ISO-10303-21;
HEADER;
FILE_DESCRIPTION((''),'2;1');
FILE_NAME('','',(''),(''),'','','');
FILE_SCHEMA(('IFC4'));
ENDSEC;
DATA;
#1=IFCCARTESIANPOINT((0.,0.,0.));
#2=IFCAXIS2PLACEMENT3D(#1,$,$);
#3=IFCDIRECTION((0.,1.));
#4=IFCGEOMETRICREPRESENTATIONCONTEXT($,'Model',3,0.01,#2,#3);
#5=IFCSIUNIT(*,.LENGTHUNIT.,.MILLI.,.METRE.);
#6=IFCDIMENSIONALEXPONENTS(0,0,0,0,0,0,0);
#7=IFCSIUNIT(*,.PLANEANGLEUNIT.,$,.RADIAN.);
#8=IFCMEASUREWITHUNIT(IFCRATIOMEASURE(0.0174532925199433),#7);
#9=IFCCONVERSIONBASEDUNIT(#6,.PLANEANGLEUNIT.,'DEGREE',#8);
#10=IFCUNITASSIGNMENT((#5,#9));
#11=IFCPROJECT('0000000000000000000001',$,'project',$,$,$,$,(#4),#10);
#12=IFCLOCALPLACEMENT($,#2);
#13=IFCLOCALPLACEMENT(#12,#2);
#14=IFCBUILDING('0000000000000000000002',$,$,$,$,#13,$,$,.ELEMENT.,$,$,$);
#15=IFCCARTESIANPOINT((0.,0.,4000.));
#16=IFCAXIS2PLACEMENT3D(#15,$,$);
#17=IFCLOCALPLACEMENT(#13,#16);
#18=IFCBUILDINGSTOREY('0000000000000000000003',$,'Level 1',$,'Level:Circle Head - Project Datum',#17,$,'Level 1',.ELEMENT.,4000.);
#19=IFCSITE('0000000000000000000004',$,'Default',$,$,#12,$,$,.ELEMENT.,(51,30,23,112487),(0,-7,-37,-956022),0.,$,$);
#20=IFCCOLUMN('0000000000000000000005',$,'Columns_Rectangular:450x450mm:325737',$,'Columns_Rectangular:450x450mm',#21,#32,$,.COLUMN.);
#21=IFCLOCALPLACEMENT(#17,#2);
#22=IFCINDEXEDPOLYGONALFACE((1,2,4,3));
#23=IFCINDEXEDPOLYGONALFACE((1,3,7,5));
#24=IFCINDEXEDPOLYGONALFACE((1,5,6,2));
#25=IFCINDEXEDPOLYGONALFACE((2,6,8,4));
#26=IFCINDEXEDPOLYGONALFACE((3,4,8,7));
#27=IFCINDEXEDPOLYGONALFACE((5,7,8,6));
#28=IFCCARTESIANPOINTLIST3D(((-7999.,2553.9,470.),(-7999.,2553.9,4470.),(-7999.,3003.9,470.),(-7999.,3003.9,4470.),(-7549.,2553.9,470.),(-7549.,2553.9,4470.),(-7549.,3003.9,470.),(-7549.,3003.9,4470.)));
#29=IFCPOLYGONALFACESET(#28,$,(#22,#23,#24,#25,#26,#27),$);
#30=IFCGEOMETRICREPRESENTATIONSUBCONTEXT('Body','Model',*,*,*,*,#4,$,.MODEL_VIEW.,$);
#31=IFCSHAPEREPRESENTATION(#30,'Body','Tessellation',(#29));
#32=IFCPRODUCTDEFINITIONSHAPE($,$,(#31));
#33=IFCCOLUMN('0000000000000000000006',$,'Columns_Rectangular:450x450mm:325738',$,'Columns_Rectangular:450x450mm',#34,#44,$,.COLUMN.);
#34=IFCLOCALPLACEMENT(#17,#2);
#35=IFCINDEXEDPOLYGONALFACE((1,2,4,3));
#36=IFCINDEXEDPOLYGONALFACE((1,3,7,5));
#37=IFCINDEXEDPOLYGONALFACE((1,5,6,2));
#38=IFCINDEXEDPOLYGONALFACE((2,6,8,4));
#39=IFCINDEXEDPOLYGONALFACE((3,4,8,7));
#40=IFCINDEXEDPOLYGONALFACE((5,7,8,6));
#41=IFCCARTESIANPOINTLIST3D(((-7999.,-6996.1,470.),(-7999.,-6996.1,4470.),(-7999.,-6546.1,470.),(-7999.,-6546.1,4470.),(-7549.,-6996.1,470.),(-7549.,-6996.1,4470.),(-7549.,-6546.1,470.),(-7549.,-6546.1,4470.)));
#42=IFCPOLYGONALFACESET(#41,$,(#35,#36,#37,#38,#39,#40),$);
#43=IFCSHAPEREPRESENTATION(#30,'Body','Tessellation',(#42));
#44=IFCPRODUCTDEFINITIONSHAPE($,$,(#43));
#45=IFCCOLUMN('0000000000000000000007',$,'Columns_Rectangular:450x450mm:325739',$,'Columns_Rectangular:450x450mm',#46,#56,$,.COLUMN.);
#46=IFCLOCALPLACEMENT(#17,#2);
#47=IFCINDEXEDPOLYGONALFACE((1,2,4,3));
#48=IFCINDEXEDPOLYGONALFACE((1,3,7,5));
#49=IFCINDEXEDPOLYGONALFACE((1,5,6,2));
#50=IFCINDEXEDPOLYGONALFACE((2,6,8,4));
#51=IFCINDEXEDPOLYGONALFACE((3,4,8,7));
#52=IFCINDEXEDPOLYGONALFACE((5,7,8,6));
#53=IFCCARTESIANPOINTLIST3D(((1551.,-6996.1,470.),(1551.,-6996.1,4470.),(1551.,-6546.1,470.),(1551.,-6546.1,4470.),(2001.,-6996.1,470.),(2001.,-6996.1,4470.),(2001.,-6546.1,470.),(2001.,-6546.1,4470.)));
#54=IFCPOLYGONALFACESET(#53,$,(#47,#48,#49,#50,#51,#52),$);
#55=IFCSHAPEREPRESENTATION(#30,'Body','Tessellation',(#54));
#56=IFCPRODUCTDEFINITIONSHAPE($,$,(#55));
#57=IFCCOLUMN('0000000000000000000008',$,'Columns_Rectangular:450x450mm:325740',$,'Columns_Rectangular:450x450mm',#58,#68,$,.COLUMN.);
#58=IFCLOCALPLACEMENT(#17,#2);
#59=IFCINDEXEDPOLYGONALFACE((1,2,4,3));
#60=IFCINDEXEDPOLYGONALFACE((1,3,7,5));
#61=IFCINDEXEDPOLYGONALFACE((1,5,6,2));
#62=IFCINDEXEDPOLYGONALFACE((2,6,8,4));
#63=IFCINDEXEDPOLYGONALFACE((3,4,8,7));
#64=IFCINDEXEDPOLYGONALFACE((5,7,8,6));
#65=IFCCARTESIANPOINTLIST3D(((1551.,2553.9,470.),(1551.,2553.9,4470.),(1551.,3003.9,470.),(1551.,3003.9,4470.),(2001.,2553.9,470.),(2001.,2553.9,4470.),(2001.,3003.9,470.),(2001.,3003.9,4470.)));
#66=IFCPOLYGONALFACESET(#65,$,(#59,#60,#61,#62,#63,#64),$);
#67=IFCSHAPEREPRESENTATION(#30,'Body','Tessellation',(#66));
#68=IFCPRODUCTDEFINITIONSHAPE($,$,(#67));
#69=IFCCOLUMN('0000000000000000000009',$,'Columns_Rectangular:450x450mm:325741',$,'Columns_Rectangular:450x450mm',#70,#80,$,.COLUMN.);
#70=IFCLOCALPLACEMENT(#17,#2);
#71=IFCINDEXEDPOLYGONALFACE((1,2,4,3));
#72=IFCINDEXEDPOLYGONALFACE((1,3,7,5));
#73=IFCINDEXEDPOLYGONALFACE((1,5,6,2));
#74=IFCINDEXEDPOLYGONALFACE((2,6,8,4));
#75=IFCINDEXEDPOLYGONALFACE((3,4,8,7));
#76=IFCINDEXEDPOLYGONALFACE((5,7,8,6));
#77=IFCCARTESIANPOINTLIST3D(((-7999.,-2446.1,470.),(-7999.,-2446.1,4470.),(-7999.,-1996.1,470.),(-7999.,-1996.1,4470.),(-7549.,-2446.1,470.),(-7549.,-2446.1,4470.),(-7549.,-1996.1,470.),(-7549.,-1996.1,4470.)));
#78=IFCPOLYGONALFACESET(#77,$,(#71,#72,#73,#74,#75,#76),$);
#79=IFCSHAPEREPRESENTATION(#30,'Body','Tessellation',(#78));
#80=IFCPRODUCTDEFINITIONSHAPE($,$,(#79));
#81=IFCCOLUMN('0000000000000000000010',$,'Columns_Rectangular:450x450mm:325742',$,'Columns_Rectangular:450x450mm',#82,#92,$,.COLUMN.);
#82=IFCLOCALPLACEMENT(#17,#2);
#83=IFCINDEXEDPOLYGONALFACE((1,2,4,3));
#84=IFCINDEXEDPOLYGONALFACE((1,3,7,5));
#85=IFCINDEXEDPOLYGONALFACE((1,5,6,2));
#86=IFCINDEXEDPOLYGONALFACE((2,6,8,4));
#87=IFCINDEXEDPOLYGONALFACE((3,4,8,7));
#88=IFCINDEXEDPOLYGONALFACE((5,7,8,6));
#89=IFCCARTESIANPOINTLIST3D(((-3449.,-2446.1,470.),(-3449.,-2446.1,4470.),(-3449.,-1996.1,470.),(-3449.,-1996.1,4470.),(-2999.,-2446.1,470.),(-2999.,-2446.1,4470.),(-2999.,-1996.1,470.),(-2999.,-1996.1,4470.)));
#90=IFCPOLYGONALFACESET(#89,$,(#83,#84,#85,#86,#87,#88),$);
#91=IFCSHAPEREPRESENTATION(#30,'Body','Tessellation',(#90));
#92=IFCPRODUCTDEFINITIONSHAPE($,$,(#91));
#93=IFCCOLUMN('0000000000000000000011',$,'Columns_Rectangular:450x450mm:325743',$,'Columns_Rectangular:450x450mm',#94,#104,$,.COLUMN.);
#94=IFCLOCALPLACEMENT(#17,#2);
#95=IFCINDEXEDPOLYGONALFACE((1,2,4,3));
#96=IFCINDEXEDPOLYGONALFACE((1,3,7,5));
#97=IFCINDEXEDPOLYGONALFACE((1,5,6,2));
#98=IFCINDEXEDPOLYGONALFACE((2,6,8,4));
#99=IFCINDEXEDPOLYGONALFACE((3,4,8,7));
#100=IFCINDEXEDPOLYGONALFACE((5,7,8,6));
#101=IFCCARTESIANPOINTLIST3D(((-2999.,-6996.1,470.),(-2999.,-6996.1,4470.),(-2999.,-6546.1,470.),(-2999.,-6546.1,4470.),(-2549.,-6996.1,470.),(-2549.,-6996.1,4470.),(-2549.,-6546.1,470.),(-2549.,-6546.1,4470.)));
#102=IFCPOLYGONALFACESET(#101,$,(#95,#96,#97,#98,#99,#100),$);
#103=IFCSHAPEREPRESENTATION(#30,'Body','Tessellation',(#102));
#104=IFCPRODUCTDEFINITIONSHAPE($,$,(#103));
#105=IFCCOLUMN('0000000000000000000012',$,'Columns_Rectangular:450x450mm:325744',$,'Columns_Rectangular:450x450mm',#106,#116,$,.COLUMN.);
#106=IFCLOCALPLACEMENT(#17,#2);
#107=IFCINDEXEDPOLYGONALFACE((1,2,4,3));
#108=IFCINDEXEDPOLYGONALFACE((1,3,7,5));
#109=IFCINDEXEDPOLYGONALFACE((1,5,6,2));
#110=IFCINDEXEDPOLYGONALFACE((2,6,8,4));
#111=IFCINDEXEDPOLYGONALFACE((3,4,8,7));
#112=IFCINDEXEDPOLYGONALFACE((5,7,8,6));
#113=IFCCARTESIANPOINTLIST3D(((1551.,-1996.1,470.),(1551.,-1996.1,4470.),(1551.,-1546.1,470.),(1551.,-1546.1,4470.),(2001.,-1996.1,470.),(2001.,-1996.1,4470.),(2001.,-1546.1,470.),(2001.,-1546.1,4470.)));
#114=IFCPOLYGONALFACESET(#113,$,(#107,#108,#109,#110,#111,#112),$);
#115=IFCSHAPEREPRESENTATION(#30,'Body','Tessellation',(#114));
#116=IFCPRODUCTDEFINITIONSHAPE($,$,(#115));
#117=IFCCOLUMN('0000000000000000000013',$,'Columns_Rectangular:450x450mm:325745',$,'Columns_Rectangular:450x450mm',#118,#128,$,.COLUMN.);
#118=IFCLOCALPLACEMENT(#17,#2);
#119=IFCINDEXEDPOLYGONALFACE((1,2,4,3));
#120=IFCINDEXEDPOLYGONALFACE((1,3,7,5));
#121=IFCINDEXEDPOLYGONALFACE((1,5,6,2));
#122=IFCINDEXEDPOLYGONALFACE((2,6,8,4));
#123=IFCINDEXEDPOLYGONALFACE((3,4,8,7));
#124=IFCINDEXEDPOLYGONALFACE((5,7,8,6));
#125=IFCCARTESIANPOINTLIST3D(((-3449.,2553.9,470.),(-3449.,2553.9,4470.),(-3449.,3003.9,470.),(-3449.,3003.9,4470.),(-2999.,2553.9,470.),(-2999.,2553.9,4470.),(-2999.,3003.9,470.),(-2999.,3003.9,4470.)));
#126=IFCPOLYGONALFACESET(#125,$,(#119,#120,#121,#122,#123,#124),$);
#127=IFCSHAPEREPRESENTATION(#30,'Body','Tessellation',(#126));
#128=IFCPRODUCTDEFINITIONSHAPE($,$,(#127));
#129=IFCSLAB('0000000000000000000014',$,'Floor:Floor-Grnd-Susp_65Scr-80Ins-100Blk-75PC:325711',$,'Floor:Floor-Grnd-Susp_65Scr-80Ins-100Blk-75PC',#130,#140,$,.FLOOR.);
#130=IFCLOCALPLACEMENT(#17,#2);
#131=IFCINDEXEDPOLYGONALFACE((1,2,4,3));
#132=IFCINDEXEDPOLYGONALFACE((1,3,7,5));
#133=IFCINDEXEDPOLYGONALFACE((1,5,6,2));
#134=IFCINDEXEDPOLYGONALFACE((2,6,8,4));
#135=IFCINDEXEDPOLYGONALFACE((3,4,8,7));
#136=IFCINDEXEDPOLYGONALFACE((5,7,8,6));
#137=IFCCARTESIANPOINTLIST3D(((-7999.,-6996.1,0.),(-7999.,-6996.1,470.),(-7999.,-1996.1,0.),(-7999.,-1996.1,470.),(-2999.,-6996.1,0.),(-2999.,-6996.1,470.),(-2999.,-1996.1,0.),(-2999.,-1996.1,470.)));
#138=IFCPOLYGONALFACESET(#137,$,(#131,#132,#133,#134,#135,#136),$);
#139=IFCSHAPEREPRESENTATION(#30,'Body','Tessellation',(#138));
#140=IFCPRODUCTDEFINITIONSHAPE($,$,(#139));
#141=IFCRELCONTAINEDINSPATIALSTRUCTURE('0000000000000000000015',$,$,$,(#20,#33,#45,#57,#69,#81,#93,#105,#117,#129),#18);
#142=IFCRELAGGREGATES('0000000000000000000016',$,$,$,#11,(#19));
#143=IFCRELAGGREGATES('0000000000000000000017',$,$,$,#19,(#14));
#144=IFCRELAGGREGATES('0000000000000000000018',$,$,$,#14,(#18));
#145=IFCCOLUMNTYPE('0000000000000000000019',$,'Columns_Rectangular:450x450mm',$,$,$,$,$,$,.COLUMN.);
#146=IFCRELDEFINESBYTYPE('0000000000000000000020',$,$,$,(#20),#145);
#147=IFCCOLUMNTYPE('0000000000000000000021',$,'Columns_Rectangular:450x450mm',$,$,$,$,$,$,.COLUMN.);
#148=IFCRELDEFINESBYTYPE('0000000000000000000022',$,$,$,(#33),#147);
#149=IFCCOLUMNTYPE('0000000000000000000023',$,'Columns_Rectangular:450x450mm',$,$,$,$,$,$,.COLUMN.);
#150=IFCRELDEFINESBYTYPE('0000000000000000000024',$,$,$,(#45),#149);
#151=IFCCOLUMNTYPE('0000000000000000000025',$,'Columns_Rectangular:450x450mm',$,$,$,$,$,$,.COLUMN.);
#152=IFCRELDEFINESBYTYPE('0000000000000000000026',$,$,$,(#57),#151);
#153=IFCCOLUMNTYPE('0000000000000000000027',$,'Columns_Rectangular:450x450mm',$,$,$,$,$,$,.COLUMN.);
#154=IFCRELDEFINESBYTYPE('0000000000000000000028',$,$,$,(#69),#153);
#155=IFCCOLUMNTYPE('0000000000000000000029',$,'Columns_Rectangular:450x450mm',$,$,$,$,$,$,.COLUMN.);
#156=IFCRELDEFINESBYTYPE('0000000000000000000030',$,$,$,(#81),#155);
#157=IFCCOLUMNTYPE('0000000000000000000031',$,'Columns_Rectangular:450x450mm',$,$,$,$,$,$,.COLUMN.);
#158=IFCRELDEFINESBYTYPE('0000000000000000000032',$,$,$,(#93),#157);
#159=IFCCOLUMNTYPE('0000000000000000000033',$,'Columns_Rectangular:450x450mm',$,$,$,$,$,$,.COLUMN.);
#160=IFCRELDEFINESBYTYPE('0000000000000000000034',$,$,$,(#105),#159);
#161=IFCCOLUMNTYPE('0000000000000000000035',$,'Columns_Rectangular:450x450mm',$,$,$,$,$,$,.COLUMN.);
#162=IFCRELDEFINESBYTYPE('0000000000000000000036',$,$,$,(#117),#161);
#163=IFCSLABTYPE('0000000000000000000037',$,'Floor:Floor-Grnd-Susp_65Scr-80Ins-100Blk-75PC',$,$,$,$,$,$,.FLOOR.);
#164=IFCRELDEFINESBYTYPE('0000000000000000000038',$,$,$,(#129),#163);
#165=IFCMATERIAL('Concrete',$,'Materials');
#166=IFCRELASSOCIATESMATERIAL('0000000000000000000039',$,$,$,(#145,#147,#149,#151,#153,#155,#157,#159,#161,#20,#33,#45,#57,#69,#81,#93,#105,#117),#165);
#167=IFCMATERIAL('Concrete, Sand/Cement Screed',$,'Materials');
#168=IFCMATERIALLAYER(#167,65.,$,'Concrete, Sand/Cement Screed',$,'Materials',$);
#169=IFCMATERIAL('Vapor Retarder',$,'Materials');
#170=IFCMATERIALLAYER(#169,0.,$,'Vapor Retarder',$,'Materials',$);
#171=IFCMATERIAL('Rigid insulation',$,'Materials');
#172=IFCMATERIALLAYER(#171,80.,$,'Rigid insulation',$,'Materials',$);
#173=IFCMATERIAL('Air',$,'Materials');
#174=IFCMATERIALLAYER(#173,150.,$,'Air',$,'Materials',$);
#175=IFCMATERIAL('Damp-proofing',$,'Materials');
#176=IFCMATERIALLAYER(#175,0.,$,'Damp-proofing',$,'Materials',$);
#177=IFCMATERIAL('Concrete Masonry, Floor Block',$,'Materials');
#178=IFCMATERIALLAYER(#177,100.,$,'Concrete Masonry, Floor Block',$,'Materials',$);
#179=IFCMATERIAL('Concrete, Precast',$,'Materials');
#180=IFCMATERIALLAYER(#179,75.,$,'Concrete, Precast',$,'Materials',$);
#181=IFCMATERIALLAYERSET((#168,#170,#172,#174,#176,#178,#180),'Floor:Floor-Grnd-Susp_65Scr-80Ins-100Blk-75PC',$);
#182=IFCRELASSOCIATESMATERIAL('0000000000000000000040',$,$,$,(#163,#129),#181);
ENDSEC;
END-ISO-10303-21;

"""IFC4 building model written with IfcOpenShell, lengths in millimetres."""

from ifc_helpers import new_model, entity, si_unit, converted_unit, direction, frame, frame_2d, origin, origin_2d_with_axis, place, context, subcontext, project, spatial, polyline, segment, composite_curve, rectangle, outline, extrude, source, transform, mapped, material, layer, layer_set, layer_usage, material_profile, profile_set, profile_usage, type_object, type_shapes, element, save


model = new_model("IFC4")

# Units and contexts
model_context = context("Model", 3, precision=0.01, world=origin(), true_north=direction((0.0, 1.0)))
body_context = subcontext(model_context, "Body", "Model", "MODEL_VIEW")
ifc_project = project(units=[si_unit("LENGTHUNIT", "METRE", prefix="MILLI"), converted_unit("PLANEANGLEUNIT", "DEGREE", entity("IfcRatioMeasure", 0.0174532925199433), si_unit("PLANEANGLEUNIT", "RADIAN"), dimensions=[0, 0, 0, 0, 0, 0, 0])], contexts=[model_context])

# Site, building, storey
site_placement = place(None, origin())
site = spatial("IfcSite", under=ifc_project, at=site_placement, Name="Default", CompositionType="ELEMENT", RefLatitude=(51, 30, 23, 112487), RefLongitude=(0, -7, -37, -956022), RefElevation=0.0)
building_placement = place(site_placement, origin())
building = spatial("IfcBuilding", under=site, at=building_placement, CompositionType="ELEMENT")
storey_placement = place(building_placement, frame((0.0, 0.0, 4000.0)))
storey = spatial("IfcBuildingStorey", under=building, at=storey_placement, Name="Level 1", ObjectType="Level:Circle Head - Project Datum", LongName="Level 1", CompositionType="ELEMENT", Elevation=4000.0)

# Columns
ifc_material_1 = material(Name="Concrete", Category="Materials")
ifc_material_profile = material_profile(ifc_material_1, outline(composite_curve([segment(polyline([(225.0, 225.0, 0.0), (225.0, -225.0, 0.0)]), True, "CONTINUOUS"), segment(polyline([(225.0, -225.0, 0.0), (-225.0, -225.0, 0.0)]), True, "CONTINUOUS"), segment(polyline([(-225.0, -225.0, 0.0), (-225.0, 225.0, 0.0)]), True, "CONTINUOUS"), segment(polyline([(-225.0, 225.0, 0.0), (225.0, 225.0, 0.0)]), True, "CONTINUOUS")], self_intersect=False), kind="CURVE"), Name="450x450mm")
ifc_profile_set = profile_set([ifc_material_profile], Name="450x450mm")
ifc_profile_usage_1 = profile_usage(ifc_profile_set)
column_type_1 = type_object("IfcColumnType", Name="Columns_Rectangular:450x450mm", PredefinedType="COLUMN", material=ifc_profile_set)
shared_shape_1 = source(origin(), body_context, "Body", "SweptSolid", [
    extrude(rectangle(XDim=450.0, YDim=450.0, at=frame_2d((0.0, 0.0), x_axis=(1.0, 0.0))), frame((-7774.0, 2778.9, 4470.0), z_axis=(0.0, 0.0, 1.0), x_axis=(0.0, -1.0, 0.0)), (0.0, 0.0, 1.0), 4000.0),
])
type_shapes(column_type_1, [shared_shape_1])
column_1_placement = place(storey_placement, frame((0.0, 0.0, -4000.0)))
element("IfcColumn", 1, at=column_1_placement, inside=storey, type_object=column_type_1, material=ifc_profile_usage_1, Name="Columns_Rectangular:450x450mm:325737", ObjectType="Columns_Rectangular:450x450mm", PredefinedType="COLUMN", context=body_context, shape_type="MappedRepresentation", body=[
    mapped(shared_shape_1, transform((0.0, 0.0, 0.0), scale=1.0)),
])
ifc_profile_usage_2 = profile_usage(ifc_profile_set)
column_type_2 = type_object("IfcColumnType", Name="Columns_Rectangular:450x450mm", PredefinedType="COLUMN", material=ifc_profile_set)
shared_shape_2 = source(origin(), body_context, "Body", "SweptSolid", [
    extrude(rectangle(XDim=450.0, YDim=450.0, at=frame_2d((0.0, 0.0), x_axis=(1.0, 0.0))), frame((-7774.0, -6771.1, 4470.0), z_axis=(0.0, 0.0, 1.0), x_axis=(0.0, -1.0, 0.0)), (0.0, 0.0, 1.0), 4000.0),
])
type_shapes(column_type_2, [shared_shape_2])
column_2_placement = place(storey_placement, frame((0.0, 0.0, -4000.0)))
element("IfcColumn", 2, at=column_2_placement, inside=storey, type_object=column_type_2, material=ifc_profile_usage_2, Name="Columns_Rectangular:450x450mm:325738", ObjectType="Columns_Rectangular:450x450mm", PredefinedType="COLUMN", context=body_context, shape_type="MappedRepresentation", body=[
    mapped(shared_shape_2, transform((0.0, 0.0, 0.0), scale=1.0)),
])
ifc_profile_usage_3 = profile_usage(ifc_profile_set)
column_type_3 = type_object("IfcColumnType", Name="Columns_Rectangular:450x450mm", PredefinedType="COLUMN", material=ifc_profile_set)
shared_shape_3 = source(origin(), body_context, "Body", "SweptSolid", [
    extrude(rectangle(XDim=450.0, YDim=450.0, at=frame_2d((0.0, 0.0), x_axis=(1.0, 0.0))), frame((1776.0, -6771.1, 4470.0), z_axis=(0.0, 0.0, 1.0), x_axis=(0.0, -1.0, 0.0)), (0.0, 0.0, 1.0), 4000.0),
])
type_shapes(column_type_3, [shared_shape_3])
column_3_placement = place(storey_placement, frame((0.0, 0.0, -4000.0)))
element("IfcColumn", 3, at=column_3_placement, inside=storey, type_object=column_type_3, material=ifc_profile_usage_3, Name="Columns_Rectangular:450x450mm:325739", ObjectType="Columns_Rectangular:450x450mm", PredefinedType="COLUMN", context=body_context, shape_type="MappedRepresentation", body=[
    mapped(shared_shape_3, transform((0.0, 0.0, 0.0), scale=1.0)),
])
ifc_profile_usage_4 = profile_usage(ifc_profile_set)
column_type_4 = type_object("IfcColumnType", Name="Columns_Rectangular:450x450mm", PredefinedType="COLUMN", material=ifc_profile_set)
shared_shape_4 = source(origin(), body_context, "Body", "SweptSolid", [
    extrude(rectangle(XDim=450.0, YDim=450.0, at=frame_2d((0.0, 0.0), x_axis=(1.0, 0.0))), frame((1776.0, 2778.9, 4470.0), z_axis=(0.0, 0.0, 1.0), x_axis=(0.0, -1.0, 0.0)), (0.0, 0.0, 1.0), 4000.0),
])
type_shapes(column_type_4, [shared_shape_4])
column_4_placement = place(storey_placement, frame((0.0, 0.0, -4000.0)))
element("IfcColumn", 4, at=column_4_placement, inside=storey, type_object=column_type_4, material=ifc_profile_usage_4, Name="Columns_Rectangular:450x450mm:325740", ObjectType="Columns_Rectangular:450x450mm", PredefinedType="COLUMN", context=body_context, shape_type="MappedRepresentation", body=[
    mapped(shared_shape_4, transform((0.0, 0.0, 0.0), scale=1.0)),
])
ifc_profile_usage_5 = profile_usage(ifc_profile_set)
column_type_5 = type_object("IfcColumnType", Name="Columns_Rectangular:450x450mm", PredefinedType="COLUMN", material=ifc_profile_set)
shared_shape_5 = source(origin(), body_context, "Body", "SweptSolid", [
    extrude(rectangle(XDim=450.0, YDim=450.0, at=frame_2d((0.0, 0.0), x_axis=(1.0, 0.0))), frame((-7774.0, -2221.1, 4470.0), z_axis=(0.0, 0.0, 1.0), x_axis=(0.0, -1.0, 0.0)), (0.0, 0.0, 1.0), 4000.0),
])
type_shapes(column_type_5, [shared_shape_5])
column_5_placement = place(storey_placement, frame((0.0, 0.0, -4000.0)))
element("IfcColumn", 5, at=column_5_placement, inside=storey, type_object=column_type_5, material=ifc_profile_usage_5, Name="Columns_Rectangular:450x450mm:325741", ObjectType="Columns_Rectangular:450x450mm", PredefinedType="COLUMN", context=body_context, shape_type="MappedRepresentation", body=[
    mapped(shared_shape_5, transform((0.0, 0.0, 0.0), scale=1.0)),
])
ifc_profile_usage_6 = profile_usage(ifc_profile_set)
column_type_6 = type_object("IfcColumnType", Name="Columns_Rectangular:450x450mm", PredefinedType="COLUMN", material=ifc_profile_set)
shared_shape_6 = source(origin(), body_context, "Body", "SweptSolid", [
    extrude(rectangle(XDim=450.0, YDim=450.0, at=origin_2d_with_axis()), frame((0.0, 0.0, 4470.0), z_axis=(0.0, 0.0, 1.0), x_axis=(0.0, -1.0, 0.0)), (0.0, 0.0, 1.0), 4000.0),
])
type_shapes(column_type_6, [shared_shape_6])
column_6_placement = place(storey_placement, frame((-3224.0, -2221.1, -4000.0)))
element("IfcColumn", 6, at=column_6_placement, inside=storey, type_object=column_type_6, material=ifc_profile_usage_6, Name="Columns_Rectangular:450x450mm:325742", ObjectType="Columns_Rectangular:450x450mm", PredefinedType="COLUMN", context=body_context, shape_type="MappedRepresentation", body=[
    mapped(shared_shape_6, transform((0.0, 0.0, 0.0), scale=1.0)),
])
ifc_profile_usage_7 = profile_usage(ifc_profile_set)
column_type_7 = type_object("IfcColumnType", Name="Columns_Rectangular:450x450mm", PredefinedType="COLUMN", material=ifc_profile_set)
shared_shape_7 = source(origin(), body_context, "Body", "SweptSolid", [
    extrude(rectangle(XDim=450.0, YDim=450.0, at=frame_2d((0.0, 0.0), x_axis=(1.0, 0.0))), frame((-2774.0, -6771.1, 4470.0), z_axis=(0.0, 0.0, 1.0), x_axis=(0.0, -1.0, 0.0)), (0.0, 0.0, 1.0), 4000.0),
])
type_shapes(column_type_7, [shared_shape_7])
column_7_placement = place(storey_placement, frame((0.0, 0.0, -4000.0)))
element("IfcColumn", 7, at=column_7_placement, inside=storey, type_object=column_type_7, material=ifc_profile_usage_7, Name="Columns_Rectangular:450x450mm:325743", ObjectType="Columns_Rectangular:450x450mm", PredefinedType="COLUMN", context=body_context, shape_type="MappedRepresentation", body=[
    mapped(shared_shape_7, transform((0.0, 0.0, 0.0), scale=1.0)),
])
ifc_profile_usage_8 = profile_usage(ifc_profile_set)
column_type_8 = type_object("IfcColumnType", Name="Columns_Rectangular:450x450mm", PredefinedType="COLUMN", material=ifc_profile_set)
shared_shape_8 = source(origin(), body_context, "Body", "SweptSolid", [
    extrude(rectangle(XDim=450.0, YDim=450.0, at=frame_2d((0.0, 0.0), x_axis=(1.0, 0.0))), frame((1776.0, -1771.1, 4470.0), z_axis=(0.0, 0.0, 1.0), x_axis=(0.0, -1.0, 0.0)), (0.0, 0.0, 1.0), 4000.0),
])
type_shapes(column_type_8, [shared_shape_8])
column_8_placement = place(storey_placement, frame((0.0, 0.0, -4000.0)))
element("IfcColumn", 8, at=column_8_placement, inside=storey, type_object=column_type_8, material=ifc_profile_usage_8, Name="Columns_Rectangular:450x450mm:325744", ObjectType="Columns_Rectangular:450x450mm", PredefinedType="COLUMN", context=body_context, shape_type="MappedRepresentation", body=[
    mapped(shared_shape_8, transform((0.0, 0.0, 0.0), scale=1.0)),
])
ifc_profile_usage_9 = profile_usage(ifc_profile_set)
column_type_9 = type_object("IfcColumnType", Name="Columns_Rectangular:450x450mm", PredefinedType="COLUMN", material=ifc_profile_set)
shared_shape_9 = source(origin(), body_context, "Body", "SweptSolid", [
    extrude(rectangle(XDim=450.0, YDim=450.0, at=frame_2d((0.0, 0.0), x_axis=(1.0, 0.0))), frame((-3224.0, 2778.9, 4470.0), z_axis=(0.0, 0.0, 1.0), x_axis=(0.0, -1.0, 0.0)), (0.0, 0.0, 1.0), 4000.0),
])
type_shapes(column_type_9, [shared_shape_9])
column_9_placement = place(storey_placement, frame((0.0, 0.0, -4000.0)))
element("IfcColumn", 9, at=column_9_placement, inside=storey, type_object=column_type_9, material=ifc_profile_usage_9, Name="Columns_Rectangular:450x450mm:325745", ObjectType="Columns_Rectangular:450x450mm", PredefinedType="COLUMN", context=body_context, shape_type="MappedRepresentation", body=[
    mapped(shared_shape_9, transform((0.0, 0.0, 0.0), scale=1.0)),
])

# Slab
ifc_material_2 = material(Name="Concrete, Sand/Cement Screed", Category="Materials")
ifc_layer_1 = layer(ifc_material_2, 65.0, Name="Concrete, Sand/Cement Screed", Category="Materials")
ifc_material_3 = material(Name="Vapor Retarder", Category="Materials")
ifc_layer_2 = layer(ifc_material_3, 0.0, Name="Vapor Retarder", Category="Materials")
ifc_material_4 = material(Name="Rigid insulation", Category="Materials")
ifc_layer_3 = layer(ifc_material_4, 80.0, Name="Rigid insulation", Category="Materials")
ifc_material_5 = material(Name="Air", Category="Materials")
ifc_layer_4 = layer(ifc_material_5, 150.0, Name="Air", Category="Materials")
ifc_material_6 = material(Name="Damp-proofing", Category="Materials")
ifc_layer_5 = layer(ifc_material_6, 0.0, Name="Damp-proofing", Category="Materials")
ifc_material_7 = material(Name="Concrete Masonry, Floor Block", Category="Materials")
ifc_layer_6 = layer(ifc_material_7, 100.0, Name="Concrete Masonry, Floor Block", Category="Materials")
ifc_material_8 = material(Name="Concrete, Precast", Category="Materials")
ifc_layer_7 = layer(ifc_material_8, 75.0, Name="Concrete, Precast", Category="Materials")
ifc_layer_set_1 = layer_set([ifc_layer_1, ifc_layer_2, ifc_layer_3, ifc_layer_4, ifc_layer_5, ifc_layer_6, ifc_layer_7], Name="Floor:Floor-Grnd-Susp_65Scr-80Ins-100Blk-75PC")
ifc_layer_usage_1 = layer_usage(ifc_layer_set_1, "AXIS3", "POSITIVE", 0.0)
slab_type_1 = type_object("IfcSlabType", Name="Floor:Floor-Grnd-Susp_65Scr-80Ins-100Blk-75PC", PredefinedType="FLOOR", material=ifc_layer_set_1)
slab_1_placement = place(storey_placement, origin())
element("IfcSlab", 10, at=slab_1_placement, inside=storey, type_object=slab_type_1, material=ifc_layer_usage_1, Name="Floor:Floor-Grnd-Susp_65Scr-80Ins-100Blk-75PC:325711", ObjectType="Floor:Floor-Grnd-Susp_65Scr-80Ins-100Blk-75PC", PredefinedType="FLOOR", context=body_context, shape_type="SweptSolid", body=[
    extrude(rectangle(XDim=5000.0, YDim=5000.0, at=frame_2d((0.0, 0.0), x_axis=(1.0, 0.0))), frame((-5499.0, -4496.1, 470.0), z_axis=(0.0, 0.0, -1.0), x_axis=(0.0, 1.0, 0.0)), (0.0, 0.0, 1.0), 470.0),
])

save(model, "model.ifc")
